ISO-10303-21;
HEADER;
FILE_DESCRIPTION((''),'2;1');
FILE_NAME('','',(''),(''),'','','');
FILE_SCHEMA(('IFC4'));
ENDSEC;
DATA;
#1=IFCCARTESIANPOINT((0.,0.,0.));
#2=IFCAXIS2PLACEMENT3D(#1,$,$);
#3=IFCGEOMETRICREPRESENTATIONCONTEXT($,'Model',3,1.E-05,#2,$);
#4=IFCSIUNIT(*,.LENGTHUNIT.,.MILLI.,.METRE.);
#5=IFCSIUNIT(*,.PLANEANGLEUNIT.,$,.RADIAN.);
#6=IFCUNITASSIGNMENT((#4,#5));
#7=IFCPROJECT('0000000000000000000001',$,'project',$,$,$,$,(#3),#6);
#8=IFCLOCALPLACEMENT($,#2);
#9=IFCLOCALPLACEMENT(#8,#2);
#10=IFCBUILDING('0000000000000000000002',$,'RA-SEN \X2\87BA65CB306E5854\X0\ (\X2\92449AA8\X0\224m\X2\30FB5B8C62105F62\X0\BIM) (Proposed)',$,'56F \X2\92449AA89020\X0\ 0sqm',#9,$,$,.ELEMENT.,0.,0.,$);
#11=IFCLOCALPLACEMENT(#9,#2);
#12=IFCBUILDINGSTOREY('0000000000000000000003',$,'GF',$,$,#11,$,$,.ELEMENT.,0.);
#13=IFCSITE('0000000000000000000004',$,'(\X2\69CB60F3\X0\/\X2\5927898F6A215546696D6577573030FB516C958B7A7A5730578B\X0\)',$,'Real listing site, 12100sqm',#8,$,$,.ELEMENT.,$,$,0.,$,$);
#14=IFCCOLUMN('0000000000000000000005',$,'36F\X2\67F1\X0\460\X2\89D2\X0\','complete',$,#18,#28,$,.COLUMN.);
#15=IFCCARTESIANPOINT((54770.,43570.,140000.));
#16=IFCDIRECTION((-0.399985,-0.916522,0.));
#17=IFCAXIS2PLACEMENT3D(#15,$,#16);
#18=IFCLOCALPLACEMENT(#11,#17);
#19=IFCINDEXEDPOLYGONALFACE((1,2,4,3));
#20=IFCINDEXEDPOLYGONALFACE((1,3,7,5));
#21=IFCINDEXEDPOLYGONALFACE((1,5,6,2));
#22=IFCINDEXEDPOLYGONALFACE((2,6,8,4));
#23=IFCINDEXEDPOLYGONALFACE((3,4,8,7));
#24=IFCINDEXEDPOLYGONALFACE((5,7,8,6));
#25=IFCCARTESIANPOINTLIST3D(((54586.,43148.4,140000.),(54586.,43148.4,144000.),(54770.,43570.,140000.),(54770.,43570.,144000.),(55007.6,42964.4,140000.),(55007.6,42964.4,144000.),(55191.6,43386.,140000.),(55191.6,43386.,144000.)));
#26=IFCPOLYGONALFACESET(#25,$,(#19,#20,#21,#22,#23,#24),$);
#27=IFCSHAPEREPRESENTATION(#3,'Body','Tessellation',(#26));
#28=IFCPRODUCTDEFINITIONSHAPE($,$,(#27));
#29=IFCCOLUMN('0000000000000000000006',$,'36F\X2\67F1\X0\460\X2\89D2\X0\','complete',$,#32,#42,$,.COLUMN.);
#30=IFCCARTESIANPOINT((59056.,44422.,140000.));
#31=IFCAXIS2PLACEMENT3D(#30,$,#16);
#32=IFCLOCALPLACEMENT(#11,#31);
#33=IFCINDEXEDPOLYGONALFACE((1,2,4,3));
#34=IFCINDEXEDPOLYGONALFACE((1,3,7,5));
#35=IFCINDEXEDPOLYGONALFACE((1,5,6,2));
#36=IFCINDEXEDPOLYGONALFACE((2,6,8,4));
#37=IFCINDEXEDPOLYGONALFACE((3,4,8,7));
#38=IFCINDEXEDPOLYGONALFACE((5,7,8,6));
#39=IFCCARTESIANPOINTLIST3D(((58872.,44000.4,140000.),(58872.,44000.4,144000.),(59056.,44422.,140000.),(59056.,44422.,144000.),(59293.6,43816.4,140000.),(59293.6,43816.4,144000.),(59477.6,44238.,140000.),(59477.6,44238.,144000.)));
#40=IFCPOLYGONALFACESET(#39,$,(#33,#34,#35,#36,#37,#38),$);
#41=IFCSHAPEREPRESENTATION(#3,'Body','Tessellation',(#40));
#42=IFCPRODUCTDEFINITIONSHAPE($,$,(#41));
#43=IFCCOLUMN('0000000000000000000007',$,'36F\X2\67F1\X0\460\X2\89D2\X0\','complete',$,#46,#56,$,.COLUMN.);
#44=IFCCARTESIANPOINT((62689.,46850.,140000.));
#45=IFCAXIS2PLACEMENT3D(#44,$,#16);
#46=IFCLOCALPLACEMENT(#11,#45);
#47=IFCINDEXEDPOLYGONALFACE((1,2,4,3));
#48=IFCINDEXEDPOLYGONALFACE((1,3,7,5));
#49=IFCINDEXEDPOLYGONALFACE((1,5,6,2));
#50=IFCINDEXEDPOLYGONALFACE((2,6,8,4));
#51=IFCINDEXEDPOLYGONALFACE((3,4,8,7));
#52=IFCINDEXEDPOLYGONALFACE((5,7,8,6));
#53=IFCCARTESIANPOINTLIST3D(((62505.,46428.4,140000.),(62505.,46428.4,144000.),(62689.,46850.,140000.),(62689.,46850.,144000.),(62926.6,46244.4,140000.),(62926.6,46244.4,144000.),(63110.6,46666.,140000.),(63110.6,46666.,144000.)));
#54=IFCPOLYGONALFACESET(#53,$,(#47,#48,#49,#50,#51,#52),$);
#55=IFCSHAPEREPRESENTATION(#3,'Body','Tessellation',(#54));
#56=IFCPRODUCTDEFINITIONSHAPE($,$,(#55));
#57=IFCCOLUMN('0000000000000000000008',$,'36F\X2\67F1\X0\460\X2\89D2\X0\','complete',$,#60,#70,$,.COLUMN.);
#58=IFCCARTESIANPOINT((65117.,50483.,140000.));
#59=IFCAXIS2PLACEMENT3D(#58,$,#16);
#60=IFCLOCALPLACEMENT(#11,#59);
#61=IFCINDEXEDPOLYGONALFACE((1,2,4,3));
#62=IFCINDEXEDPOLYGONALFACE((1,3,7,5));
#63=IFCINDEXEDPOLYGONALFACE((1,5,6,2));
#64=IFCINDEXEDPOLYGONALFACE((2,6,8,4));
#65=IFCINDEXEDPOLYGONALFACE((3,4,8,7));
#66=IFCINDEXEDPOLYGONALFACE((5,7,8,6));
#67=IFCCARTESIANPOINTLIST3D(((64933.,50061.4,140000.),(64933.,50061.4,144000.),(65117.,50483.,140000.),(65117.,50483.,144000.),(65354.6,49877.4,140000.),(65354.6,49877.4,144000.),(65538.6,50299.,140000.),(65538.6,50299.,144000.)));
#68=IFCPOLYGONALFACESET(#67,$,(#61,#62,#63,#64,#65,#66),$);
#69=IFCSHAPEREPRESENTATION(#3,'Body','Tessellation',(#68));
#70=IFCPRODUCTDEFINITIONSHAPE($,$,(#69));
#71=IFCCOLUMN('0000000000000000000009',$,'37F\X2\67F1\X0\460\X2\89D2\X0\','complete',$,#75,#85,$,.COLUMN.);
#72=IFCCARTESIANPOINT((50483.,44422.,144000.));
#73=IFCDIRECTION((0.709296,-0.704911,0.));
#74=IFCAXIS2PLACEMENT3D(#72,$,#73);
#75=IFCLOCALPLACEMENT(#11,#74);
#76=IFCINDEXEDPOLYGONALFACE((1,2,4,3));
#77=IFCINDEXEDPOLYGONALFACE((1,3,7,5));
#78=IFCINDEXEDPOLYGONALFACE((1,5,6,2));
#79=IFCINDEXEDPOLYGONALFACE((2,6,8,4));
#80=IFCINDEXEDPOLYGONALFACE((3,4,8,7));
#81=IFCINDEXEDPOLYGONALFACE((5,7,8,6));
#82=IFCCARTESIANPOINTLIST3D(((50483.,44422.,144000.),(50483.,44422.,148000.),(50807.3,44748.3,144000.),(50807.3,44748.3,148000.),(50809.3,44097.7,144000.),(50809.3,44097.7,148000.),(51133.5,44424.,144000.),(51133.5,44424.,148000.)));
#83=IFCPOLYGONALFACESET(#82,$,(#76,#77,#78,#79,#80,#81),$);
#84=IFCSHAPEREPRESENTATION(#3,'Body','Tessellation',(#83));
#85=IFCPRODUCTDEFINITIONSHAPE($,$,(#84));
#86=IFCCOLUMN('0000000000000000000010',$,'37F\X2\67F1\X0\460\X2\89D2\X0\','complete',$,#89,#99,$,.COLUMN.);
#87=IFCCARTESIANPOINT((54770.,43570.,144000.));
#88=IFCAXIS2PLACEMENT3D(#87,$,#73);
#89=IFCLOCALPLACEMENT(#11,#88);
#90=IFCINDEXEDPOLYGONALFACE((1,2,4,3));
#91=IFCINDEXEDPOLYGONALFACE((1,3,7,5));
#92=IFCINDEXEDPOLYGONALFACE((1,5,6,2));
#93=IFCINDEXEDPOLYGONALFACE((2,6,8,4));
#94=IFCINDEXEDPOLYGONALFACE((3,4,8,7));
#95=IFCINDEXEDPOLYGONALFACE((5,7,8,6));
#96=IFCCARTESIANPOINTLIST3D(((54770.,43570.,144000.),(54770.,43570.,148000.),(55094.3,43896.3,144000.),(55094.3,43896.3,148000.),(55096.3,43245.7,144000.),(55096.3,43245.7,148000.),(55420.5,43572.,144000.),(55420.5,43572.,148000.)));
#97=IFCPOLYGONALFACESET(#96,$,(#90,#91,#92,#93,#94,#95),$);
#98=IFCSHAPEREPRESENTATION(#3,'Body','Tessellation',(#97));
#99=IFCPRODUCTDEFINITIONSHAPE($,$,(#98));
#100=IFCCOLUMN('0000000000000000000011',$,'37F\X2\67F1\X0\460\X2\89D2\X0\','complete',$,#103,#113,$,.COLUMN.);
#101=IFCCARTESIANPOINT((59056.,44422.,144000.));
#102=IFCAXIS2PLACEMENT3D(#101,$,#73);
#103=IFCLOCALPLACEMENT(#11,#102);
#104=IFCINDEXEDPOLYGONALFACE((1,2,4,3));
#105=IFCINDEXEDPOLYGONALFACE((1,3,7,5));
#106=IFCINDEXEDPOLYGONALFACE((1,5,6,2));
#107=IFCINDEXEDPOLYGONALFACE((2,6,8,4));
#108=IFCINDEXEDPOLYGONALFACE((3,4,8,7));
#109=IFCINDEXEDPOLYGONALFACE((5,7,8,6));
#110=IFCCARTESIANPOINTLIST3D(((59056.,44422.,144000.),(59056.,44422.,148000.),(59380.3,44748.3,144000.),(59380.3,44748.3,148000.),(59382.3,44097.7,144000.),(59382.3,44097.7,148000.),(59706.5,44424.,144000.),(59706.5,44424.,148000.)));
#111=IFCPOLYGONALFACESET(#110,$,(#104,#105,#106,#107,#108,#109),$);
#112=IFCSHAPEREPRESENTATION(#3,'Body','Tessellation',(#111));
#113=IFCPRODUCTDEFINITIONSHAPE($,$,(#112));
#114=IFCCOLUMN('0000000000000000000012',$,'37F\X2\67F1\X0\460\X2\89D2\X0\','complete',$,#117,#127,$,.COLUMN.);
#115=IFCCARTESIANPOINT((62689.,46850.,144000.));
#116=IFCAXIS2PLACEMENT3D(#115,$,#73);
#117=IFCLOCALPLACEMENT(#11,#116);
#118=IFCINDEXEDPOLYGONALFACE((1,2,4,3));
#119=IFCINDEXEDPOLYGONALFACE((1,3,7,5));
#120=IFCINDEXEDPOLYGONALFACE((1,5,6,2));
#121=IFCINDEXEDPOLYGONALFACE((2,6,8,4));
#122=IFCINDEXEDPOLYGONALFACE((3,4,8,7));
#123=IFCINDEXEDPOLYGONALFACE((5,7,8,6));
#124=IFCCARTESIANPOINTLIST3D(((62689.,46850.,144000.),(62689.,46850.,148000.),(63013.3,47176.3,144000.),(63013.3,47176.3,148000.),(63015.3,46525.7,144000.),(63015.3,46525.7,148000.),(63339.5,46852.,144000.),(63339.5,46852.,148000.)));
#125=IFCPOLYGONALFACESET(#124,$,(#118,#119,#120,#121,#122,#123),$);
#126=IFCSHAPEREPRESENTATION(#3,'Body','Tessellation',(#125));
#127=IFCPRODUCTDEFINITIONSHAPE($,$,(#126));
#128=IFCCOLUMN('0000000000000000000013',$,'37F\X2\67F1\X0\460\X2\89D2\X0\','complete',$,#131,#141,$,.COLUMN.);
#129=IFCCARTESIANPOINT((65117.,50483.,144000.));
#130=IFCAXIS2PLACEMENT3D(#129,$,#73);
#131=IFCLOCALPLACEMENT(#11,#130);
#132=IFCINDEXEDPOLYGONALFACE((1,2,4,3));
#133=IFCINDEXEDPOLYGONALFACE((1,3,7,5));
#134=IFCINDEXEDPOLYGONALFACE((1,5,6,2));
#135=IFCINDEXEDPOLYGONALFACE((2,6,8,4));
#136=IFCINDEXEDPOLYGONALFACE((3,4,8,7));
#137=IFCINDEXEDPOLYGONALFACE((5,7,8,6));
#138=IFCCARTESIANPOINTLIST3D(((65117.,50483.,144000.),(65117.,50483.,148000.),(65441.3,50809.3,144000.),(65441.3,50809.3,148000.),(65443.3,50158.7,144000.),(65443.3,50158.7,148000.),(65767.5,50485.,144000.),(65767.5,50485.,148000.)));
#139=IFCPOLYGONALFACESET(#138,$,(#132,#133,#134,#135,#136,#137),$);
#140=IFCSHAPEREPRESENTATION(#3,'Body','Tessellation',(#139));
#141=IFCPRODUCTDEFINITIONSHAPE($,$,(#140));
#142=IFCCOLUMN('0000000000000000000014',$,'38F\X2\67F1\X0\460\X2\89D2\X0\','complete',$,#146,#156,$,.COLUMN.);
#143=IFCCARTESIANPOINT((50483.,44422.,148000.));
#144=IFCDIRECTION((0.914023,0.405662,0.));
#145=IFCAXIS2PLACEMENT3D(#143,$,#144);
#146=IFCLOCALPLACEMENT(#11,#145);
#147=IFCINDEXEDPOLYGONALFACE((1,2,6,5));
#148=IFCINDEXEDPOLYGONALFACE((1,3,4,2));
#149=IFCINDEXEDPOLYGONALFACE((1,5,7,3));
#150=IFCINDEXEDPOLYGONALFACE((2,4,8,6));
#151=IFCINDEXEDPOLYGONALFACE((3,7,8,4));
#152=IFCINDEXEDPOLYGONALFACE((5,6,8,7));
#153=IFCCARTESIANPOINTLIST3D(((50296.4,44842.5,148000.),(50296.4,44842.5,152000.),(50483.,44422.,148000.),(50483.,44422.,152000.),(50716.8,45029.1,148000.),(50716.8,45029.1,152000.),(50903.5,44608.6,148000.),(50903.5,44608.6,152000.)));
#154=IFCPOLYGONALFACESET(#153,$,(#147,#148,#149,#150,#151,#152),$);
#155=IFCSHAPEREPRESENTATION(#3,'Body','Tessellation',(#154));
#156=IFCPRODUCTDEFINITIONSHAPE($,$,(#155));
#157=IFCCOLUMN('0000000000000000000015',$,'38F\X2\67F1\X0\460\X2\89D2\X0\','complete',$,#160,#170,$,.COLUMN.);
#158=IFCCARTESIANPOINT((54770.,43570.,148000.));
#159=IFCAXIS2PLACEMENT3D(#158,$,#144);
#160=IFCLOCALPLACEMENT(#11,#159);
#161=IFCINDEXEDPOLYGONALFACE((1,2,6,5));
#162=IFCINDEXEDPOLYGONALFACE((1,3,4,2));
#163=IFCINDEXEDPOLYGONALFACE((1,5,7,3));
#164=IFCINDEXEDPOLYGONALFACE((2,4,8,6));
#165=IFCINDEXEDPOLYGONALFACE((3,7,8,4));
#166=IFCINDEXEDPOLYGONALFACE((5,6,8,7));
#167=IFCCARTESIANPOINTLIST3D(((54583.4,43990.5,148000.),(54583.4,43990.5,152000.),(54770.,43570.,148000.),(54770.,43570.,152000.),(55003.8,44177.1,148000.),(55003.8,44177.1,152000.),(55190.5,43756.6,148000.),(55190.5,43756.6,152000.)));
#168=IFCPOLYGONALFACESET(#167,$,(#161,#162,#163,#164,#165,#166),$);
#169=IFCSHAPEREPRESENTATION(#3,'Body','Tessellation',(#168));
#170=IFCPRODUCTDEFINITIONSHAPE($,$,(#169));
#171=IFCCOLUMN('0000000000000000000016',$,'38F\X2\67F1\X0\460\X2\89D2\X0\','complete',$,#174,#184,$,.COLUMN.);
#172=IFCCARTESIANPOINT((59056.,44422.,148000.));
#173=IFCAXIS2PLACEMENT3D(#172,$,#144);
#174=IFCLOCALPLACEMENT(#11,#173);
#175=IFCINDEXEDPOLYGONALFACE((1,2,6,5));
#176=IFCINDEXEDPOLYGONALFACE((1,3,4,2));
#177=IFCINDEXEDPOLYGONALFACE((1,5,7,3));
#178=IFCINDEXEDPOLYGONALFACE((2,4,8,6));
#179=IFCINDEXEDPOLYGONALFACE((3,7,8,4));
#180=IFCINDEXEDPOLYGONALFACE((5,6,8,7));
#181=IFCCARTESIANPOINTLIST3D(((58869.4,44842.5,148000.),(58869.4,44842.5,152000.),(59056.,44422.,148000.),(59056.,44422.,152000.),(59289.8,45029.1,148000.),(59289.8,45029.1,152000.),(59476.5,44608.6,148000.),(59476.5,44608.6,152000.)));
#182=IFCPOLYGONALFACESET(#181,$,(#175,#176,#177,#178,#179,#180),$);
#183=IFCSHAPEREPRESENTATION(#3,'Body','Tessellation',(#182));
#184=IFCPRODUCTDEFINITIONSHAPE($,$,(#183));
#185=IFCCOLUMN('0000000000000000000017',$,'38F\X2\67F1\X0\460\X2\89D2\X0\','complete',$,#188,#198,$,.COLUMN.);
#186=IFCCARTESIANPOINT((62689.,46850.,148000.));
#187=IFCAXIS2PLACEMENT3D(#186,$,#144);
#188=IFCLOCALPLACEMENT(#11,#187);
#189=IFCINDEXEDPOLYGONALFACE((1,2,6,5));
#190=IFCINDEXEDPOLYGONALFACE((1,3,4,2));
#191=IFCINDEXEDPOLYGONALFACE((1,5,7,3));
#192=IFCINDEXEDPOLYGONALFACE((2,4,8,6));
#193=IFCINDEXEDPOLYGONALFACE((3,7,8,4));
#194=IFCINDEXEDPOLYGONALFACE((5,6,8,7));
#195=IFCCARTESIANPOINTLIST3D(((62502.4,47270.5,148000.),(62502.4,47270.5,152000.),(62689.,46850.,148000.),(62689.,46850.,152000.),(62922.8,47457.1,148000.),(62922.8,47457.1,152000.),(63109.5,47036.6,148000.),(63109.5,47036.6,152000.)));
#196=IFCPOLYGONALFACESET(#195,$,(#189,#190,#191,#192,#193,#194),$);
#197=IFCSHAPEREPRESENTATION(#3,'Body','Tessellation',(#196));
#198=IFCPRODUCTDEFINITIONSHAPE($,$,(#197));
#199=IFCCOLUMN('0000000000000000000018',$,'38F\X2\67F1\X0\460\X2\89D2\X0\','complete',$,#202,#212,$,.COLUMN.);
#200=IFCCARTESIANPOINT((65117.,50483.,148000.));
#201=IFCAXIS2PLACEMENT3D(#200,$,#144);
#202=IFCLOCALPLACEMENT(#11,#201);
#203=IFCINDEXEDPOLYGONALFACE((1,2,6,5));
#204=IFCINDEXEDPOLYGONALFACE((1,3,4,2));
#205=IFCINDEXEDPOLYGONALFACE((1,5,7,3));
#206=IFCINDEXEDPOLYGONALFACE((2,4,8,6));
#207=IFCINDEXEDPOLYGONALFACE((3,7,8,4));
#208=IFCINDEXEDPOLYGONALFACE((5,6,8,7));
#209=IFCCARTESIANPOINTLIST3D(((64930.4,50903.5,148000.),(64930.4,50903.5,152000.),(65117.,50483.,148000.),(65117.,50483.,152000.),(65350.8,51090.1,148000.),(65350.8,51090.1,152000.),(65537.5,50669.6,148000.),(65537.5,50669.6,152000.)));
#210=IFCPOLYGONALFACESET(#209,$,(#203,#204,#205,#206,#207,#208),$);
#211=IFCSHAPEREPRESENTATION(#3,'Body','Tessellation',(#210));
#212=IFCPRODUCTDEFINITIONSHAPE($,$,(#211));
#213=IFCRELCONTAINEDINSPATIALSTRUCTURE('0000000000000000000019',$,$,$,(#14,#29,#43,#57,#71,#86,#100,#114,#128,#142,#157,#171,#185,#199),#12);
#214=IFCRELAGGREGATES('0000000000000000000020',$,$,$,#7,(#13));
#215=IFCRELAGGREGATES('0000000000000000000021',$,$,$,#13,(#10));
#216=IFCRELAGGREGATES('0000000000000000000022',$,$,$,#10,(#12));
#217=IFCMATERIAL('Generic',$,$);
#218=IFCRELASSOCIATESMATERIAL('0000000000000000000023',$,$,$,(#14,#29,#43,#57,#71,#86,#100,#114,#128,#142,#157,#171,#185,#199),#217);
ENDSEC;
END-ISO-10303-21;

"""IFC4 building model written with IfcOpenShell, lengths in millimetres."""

from ifc_helpers import new_model, si_unit, frame, frame_2d, origin, place, context, project, spatial, rectangle, extrude, material, element, save


model = new_model("IFC4")

# Units and contexts
model_context = context("Model", 3, precision=1e-05, world=origin())
ifc_project = project(units=[si_unit("LENGTHUNIT", "METRE", prefix="MILLI"), si_unit("PLANEANGLEUNIT", "RADIAN")], contexts=[model_context])

# Site, building, storey
site_placement = place(None, origin())
site = spatial("IfcSite", under=ifc_project, at=site_placement, Name="(構想/大規模商業敷地・公開空地型)", ObjectType="Real listing site, 12100sqm", CompositionType="ELEMENT", RefElevation=0.0)
building_placement = place(site_placement, origin())
building = spatial("IfcBuilding", under=site, at=building_placement, Name="RA-SEN 螺旋の塔 (鉄骨224m・完成形BIM) (Proposed)", ObjectType="56F 鉄骨造 0sqm", CompositionType="ELEMENT", ElevationOfRefHeight=0.0, ElevationOfTerrain=0.0)
storey_placement = place(building_placement, origin())
storey = spatial("IfcBuildingStorey", under=building, at=storey_placement, Name="GF", CompositionType="ELEMENT", Elevation=0.0)

# Columns
ifc_material = material(Name="Generic")
column_1_placement = place(storey_placement, frame((54770.0, 43570.0, 140000.0), x_axis=(-0.399985, -0.916522, 0.0)))
element("IfcColumn", 1, at=column_1_placement, inside=storey, material=ifc_material, Name="36F柱460角", Description="complete", PredefinedType="COLUMN", context=model_context, shape_type="SweptSolid", body=[
    extrude(rectangle(XDim=460.0, YDim=460.0, at=frame_2d((230.0, 230.0))), frame((54770.0, 43570.0, 140000.0), x_axis=(-0.399985, -0.916522, 0.0)), (0.0, 0.0, 1.0), 4000.0),
])
column_2_placement = place(storey_placement, frame((59056.0, 44422.0, 140000.0), x_axis=(-0.399985, -0.916522, 0.0)))
element("IfcColumn", 2, at=column_2_placement, inside=storey, material=ifc_material, Name="36F柱460角", Description="complete", PredefinedType="COLUMN", context=model_context, shape_type="SweptSolid", body=[
    extrude(rectangle(XDim=460.0, YDim=460.0, at=frame_2d((230.0, 230.0))), frame((59056.0, 44422.0, 140000.0), x_axis=(-0.399985, -0.916522, 0.0)), (0.0, 0.0, 1.0), 4000.0),
])
column_3_placement = place(storey_placement, frame((62689.0, 46850.0, 140000.0), x_axis=(-0.399985, -0.916522, 0.0)))
element("IfcColumn", 3, at=column_3_placement, inside=storey, material=ifc_material, Name="36F柱460角", Description="complete", PredefinedType="COLUMN", context=model_context, shape_type="SweptSolid", body=[
    extrude(rectangle(XDim=460.0, YDim=460.0, at=frame_2d((230.0, 230.0))), frame((62689.0, 46850.0, 140000.0), x_axis=(-0.399985, -0.916522, 0.0)), (0.0, 0.0, 1.0), 4000.0),
])
column_4_placement = place(storey_placement, frame((65117.0, 50483.0, 140000.0), x_axis=(-0.399985, -0.916522, 0.0)))
element("IfcColumn", 4, at=column_4_placement, inside=storey, material=ifc_material, Name="36F柱460角", Description="complete", PredefinedType="COLUMN", context=model_context, shape_type="SweptSolid", body=[
    extrude(rectangle(XDim=460.0, YDim=460.0, at=frame_2d((230.0, 230.0))), frame((65117.0, 50483.0, 140000.0), x_axis=(-0.399985, -0.916522, 0.0)), (0.0, 0.0, 1.0), 4000.0),
])
column_5_placement = place(storey_placement, frame((50483.0, 44422.0, 144000.0), x_axis=(0.709296, -0.704911, 0.0)))
element("IfcColumn", 5, at=column_5_placement, inside=storey, material=ifc_material, Name="37F柱460角", Description="complete", PredefinedType="COLUMN", context=model_context, shape_type="SweptSolid", body=[
    extrude(rectangle(XDim=460.0, YDim=460.0, at=frame_2d((230.0, 230.0))), frame((50483.0, 44422.0, 144000.0), x_axis=(0.709296, -0.704911, 0.0)), (0.0, 0.0, 1.0), 4000.0),
])
column_6_placement = place(storey_placement, frame((54770.0, 43570.0, 144000.0), x_axis=(0.709296, -0.704911, 0.0)))
element("IfcColumn", 6, at=column_6_placement, inside=storey, material=ifc_material, Name="37F柱460角", Description="complete", PredefinedType="COLUMN", context=model_context, shape_type="SweptSolid", body=[
    extrude(rectangle(XDim=460.0, YDim=460.0, at=frame_2d((230.0, 230.0))), frame((54770.0, 43570.0, 144000.0), x_axis=(0.709296, -0.704911, 0.0)), (0.0, 0.0, 1.0), 4000.0),
])
column_7_placement = place(storey_placement, frame((59056.0, 44422.0, 144000.0), x_axis=(0.709296, -0.704911, 0.0)))
element("IfcColumn", 7, at=column_7_placement, inside=storey, material=ifc_material, Name="37F柱460角", Description="complete", PredefinedType="COLUMN", context=model_context, shape_type="SweptSolid", body=[
    extrude(rectangle(XDim=460.0, YDim=460.0, at=frame_2d((230.0, 230.0))), frame((59056.0, 44422.0, 144000.0), x_axis=(0.709296, -0.704911, 0.0)), (0.0, 0.0, 1.0), 4000.0),
])
column_8_placement = place(storey_placement, frame((62689.0, 46850.0, 144000.0), x_axis=(0.709296, -0.704911, 0.0)))
element("IfcColumn", 8, at=column_8_placement, inside=storey, material=ifc_material, Name="37F柱460角", Description="complete", PredefinedType="COLUMN", context=model_context, shape_type="SweptSolid", body=[
    extrude(rectangle(XDim=460.0, YDim=460.0, at=frame_2d((230.0, 230.0))), frame((62689.0, 46850.0, 144000.0), x_axis=(0.709296, -0.704911, 0.0)), (0.0, 0.0, 1.0), 4000.0),
])
column_9_placement = place(storey_placement, frame((65117.0, 50483.0, 144000.0), x_axis=(0.709296, -0.704911, 0.0)))
element("IfcColumn", 9, at=column_9_placement, inside=storey, material=ifc_material, Name="37F柱460角", Description="complete", PredefinedType="COLUMN", context=model_context, shape_type="SweptSolid", body=[
    extrude(rectangle(XDim=460.0, YDim=460.0, at=frame_2d((230.0, 230.0))), frame((65117.0, 50483.0, 144000.0), x_axis=(0.709296, -0.704911, 0.0)), (0.0, 0.0, 1.0), 4000.0),
])
column_10_placement = place(storey_placement, frame((50483.0, 44422.0, 148000.0), x_axis=(0.914023, 0.405662, 0.0)))
element("IfcColumn", 10, at=column_10_placement, inside=storey, material=ifc_material, Name="38F柱460角", Description="complete", PredefinedType="COLUMN", context=model_context, shape_type="SweptSolid", body=[
    extrude(rectangle(XDim=460.0, YDim=460.0, at=frame_2d((230.0, 230.0))), frame((50483.0, 44422.0, 148000.0), x_axis=(0.914023, 0.405662, 0.0)), (0.0, 0.0, 1.0), 4000.0),
])
column_11_placement = place(storey_placement, frame((54770.0, 43570.0, 148000.0), x_axis=(0.914023, 0.405662, 0.0)))
element("IfcColumn", 11, at=column_11_placement, inside=storey, material=ifc_material, Name="38F柱460角", Description="complete", PredefinedType="COLUMN", context=model_context, shape_type="SweptSolid", body=[
    extrude(rectangle(XDim=460.0, YDim=460.0, at=frame_2d((230.0, 230.0))), frame((54770.0, 43570.0, 148000.0), x_axis=(0.914023, 0.405662, 0.0)), (0.0, 0.0, 1.0), 4000.0),
])
column_12_placement = place(storey_placement, frame((59056.0, 44422.0, 148000.0), x_axis=(0.914023, 0.405662, 0.0)))
element("IfcColumn", 12, at=column_12_placement, inside=storey, material=ifc_material, Name="38F柱460角", Description="complete", PredefinedType="COLUMN", context=model_context, shape_type="SweptSolid", body=[
    extrude(rectangle(XDim=460.0, YDim=460.0, at=frame_2d((230.0, 230.0))), frame((59056.0, 44422.0, 148000.0), x_axis=(0.914023, 0.405662, 0.0)), (0.0, 0.0, 1.0), 4000.0),
])
column_13_placement = place(storey_placement, frame((62689.0, 46850.0, 148000.0), x_axis=(0.914023, 0.405662, 0.0)))
element("IfcColumn", 13, at=column_13_placement, inside=storey, material=ifc_material, Name="38F柱460角", Description="complete", PredefinedType="COLUMN", context=model_context, shape_type="SweptSolid", body=[
    extrude(rectangle(XDim=460.0, YDim=460.0, at=frame_2d((230.0, 230.0))), frame((62689.0, 46850.0, 148000.0), x_axis=(0.914023, 0.405662, 0.0)), (0.0, 0.0, 1.0), 4000.0),
])
column_14_placement = place(storey_placement, frame((65117.0, 50483.0, 148000.0), x_axis=(0.914023, 0.405662, 0.0)))
element("IfcColumn", 14, at=column_14_placement, inside=storey, material=ifc_material, Name="38F柱460角", Description="complete", PredefinedType="COLUMN", context=model_context, shape_type="SweptSolid", body=[
    extrude(rectangle(XDim=460.0, YDim=460.0, at=frame_2d((230.0, 230.0))), frame((65117.0, 50483.0, 148000.0), x_axis=(0.914023, 0.405662, 0.0)), (0.0, 0.0, 1.0), 4000.0),
])

save(model, "model.ifc")
